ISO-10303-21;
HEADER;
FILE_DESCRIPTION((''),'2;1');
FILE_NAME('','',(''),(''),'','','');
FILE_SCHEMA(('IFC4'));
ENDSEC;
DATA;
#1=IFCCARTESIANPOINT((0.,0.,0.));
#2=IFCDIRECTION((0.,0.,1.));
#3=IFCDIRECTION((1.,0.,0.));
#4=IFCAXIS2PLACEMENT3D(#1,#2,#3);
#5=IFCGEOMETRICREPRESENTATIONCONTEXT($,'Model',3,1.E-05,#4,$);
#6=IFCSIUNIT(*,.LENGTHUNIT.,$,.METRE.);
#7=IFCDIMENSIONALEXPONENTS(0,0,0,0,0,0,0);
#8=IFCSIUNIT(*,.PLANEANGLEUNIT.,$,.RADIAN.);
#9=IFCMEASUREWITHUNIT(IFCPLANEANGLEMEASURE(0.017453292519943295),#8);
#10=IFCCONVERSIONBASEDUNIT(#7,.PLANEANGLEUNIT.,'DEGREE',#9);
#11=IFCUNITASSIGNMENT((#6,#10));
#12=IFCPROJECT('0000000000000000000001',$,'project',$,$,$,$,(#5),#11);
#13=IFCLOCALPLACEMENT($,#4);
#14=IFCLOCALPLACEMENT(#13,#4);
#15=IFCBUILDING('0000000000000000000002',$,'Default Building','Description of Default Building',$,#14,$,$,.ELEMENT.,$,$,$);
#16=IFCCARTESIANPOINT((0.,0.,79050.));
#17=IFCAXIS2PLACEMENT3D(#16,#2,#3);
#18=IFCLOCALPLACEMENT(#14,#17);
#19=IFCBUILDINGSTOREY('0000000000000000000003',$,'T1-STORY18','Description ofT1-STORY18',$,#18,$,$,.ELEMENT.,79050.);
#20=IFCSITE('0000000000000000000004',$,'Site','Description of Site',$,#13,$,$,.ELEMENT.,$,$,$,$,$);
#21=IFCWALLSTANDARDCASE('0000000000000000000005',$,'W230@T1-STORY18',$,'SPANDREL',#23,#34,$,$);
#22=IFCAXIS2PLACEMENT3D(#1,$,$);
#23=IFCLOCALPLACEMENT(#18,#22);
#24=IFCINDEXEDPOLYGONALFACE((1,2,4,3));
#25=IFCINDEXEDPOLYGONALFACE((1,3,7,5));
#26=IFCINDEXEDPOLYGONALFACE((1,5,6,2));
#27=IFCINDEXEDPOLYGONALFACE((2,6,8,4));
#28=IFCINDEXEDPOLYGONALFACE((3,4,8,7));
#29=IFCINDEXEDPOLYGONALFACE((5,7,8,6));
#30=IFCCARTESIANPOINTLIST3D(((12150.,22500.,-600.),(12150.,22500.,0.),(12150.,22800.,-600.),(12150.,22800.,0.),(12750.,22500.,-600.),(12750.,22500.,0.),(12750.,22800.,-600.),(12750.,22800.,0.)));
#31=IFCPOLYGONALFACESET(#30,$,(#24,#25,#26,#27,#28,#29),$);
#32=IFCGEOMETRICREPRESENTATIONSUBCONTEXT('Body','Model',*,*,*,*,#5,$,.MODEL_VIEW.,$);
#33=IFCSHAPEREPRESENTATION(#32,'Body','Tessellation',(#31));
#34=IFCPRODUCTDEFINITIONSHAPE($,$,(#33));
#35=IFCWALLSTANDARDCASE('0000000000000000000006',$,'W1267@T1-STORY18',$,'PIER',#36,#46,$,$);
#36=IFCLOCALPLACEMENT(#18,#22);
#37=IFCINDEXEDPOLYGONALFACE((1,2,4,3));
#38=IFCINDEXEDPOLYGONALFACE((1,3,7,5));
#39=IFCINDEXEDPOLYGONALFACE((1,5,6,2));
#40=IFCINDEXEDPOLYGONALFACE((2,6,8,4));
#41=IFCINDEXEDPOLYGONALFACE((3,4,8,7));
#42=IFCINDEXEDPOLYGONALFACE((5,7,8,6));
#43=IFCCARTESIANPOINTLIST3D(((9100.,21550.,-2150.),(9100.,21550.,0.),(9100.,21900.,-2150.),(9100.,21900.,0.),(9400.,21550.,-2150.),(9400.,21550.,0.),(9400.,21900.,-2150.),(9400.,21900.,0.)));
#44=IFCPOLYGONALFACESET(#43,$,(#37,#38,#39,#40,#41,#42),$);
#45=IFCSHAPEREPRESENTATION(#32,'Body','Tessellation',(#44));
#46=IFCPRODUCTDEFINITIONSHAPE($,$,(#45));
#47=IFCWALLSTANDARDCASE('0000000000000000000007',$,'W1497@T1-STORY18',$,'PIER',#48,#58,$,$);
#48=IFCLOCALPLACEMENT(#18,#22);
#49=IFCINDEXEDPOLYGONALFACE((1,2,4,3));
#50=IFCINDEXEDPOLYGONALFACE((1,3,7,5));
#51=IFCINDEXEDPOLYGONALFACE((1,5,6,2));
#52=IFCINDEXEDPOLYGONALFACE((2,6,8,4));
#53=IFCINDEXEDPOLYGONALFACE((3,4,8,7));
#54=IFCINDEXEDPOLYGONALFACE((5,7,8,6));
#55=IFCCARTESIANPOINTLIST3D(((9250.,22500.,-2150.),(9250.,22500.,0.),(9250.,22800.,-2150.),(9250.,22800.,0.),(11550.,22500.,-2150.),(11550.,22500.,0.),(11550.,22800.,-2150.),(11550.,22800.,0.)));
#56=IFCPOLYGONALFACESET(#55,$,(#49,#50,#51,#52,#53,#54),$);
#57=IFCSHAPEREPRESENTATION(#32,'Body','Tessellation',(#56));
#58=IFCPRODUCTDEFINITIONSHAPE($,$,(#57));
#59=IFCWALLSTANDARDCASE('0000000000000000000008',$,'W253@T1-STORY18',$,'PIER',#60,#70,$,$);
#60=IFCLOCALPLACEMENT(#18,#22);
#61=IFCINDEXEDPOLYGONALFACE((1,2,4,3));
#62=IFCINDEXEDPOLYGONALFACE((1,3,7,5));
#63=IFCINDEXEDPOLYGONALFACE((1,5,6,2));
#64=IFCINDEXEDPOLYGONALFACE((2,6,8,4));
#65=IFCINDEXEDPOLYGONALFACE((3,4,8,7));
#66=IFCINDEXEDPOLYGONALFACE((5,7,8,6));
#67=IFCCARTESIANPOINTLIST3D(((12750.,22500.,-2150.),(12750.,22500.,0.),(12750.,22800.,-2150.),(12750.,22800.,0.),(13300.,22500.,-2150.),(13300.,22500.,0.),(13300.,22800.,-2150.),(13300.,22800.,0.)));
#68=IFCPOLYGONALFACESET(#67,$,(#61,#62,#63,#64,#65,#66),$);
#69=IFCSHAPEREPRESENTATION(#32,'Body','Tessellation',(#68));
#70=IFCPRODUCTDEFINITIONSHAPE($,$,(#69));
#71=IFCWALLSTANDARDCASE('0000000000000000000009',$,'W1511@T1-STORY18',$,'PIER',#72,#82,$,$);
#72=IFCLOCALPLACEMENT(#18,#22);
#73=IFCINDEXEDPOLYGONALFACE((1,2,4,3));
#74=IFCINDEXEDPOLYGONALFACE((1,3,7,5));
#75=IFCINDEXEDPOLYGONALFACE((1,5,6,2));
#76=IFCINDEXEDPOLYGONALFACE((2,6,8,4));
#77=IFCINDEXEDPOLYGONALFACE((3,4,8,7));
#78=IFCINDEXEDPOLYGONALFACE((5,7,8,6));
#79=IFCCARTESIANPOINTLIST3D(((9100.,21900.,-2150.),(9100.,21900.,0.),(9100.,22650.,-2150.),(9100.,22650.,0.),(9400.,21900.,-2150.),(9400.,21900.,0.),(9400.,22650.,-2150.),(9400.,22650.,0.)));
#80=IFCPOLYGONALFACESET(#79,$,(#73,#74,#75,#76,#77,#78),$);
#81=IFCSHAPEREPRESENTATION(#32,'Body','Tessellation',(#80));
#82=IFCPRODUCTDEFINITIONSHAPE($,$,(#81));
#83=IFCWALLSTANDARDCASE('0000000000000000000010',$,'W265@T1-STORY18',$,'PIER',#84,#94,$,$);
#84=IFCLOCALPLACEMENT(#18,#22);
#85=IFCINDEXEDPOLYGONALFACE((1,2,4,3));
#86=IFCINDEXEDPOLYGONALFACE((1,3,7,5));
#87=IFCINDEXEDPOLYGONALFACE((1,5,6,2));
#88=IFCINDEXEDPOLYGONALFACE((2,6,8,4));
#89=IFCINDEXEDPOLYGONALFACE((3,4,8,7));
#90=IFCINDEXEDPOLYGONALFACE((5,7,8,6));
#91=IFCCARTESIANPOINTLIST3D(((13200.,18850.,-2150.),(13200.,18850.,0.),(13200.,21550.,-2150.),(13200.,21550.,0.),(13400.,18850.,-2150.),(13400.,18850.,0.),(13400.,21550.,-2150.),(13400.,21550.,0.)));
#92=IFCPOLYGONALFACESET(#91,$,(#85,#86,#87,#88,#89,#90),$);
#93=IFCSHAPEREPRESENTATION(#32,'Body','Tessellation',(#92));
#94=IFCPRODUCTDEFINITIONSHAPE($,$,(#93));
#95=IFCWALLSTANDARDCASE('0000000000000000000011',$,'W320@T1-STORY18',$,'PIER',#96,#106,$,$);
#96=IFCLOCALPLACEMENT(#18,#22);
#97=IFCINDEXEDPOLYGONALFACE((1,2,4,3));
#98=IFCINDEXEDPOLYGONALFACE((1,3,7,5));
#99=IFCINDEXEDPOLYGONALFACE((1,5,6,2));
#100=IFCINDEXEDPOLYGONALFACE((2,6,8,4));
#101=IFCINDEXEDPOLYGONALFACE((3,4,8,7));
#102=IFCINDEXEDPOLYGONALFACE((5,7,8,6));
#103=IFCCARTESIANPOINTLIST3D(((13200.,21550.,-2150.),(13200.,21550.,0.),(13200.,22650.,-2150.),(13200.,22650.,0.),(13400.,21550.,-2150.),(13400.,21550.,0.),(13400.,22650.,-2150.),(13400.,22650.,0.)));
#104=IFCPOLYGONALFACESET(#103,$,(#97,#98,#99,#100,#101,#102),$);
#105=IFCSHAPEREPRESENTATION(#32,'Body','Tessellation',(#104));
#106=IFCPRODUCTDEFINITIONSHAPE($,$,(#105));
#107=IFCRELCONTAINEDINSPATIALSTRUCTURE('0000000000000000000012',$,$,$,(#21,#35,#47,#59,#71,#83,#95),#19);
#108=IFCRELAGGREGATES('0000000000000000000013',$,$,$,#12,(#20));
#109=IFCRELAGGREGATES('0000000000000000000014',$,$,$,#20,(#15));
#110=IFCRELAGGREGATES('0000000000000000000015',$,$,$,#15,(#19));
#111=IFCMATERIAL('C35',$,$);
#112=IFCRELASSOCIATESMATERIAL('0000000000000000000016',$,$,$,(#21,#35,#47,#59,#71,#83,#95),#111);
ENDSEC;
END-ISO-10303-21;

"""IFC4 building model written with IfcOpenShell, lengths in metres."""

from ifc_helpers import new_model, entity, si_unit, converted_unit, frame, origin_with_axes, place, context, subcontext, project, spatial, indexed_curve, outline, extrude, material, element, save


model = new_model("IFC4")

# Units and contexts
model_context = context("Model", 3, precision=1e-05, world=origin_with_axes())
body_context = subcontext(model_context, "Body", "Model", "MODEL_VIEW")
ifc_project = project(units=[si_unit("LENGTHUNIT", "METRE"), converted_unit("PLANEANGLEUNIT", "DEGREE", entity("IfcPlaneAngleMeasure", 0.017453292519943295), si_unit("PLANEANGLEUNIT", "RADIAN"), dimensions=[0, 0, 0, 0, 0, 0, 0])], contexts=[model_context])

# Site, building, storey
site_placement = place(None, origin_with_axes())
site = spatial("IfcSite", under=ifc_project, at=site_placement, Name="Site", Description="Description of Site", CompositionType="ELEMENT")
building_placement = place(site_placement, origin_with_axes())
building = spatial("IfcBuilding", under=site, at=building_placement, Name="Default Building", Description="Description of Default Building", CompositionType="ELEMENT")
storey_placement = place(building_placement, frame((0.0, 0.0, 79050.0), z_axis=(0.0, 0.0, 1.0), x_axis=(1.0, 0.0, 0.0)))
storey = spatial("IfcBuildingStorey", under=building, at=storey_placement, Name="T1-STORY18", Description="Description ofT1-STORY18", CompositionType="ELEMENT", Elevation=79050.0)

# Shared definitions
ifc_material_1 = material(Name="C35")

# Walls
for number, where, z_axis, x_axis, name in (
    (1, (12150.0, 22650.0, -600.0), (0.0, 0.0, 1.0), (1.0, 0.0, 0.0), "W230@T1-STORY18"),
):
    element("IfcWallStandardCase", number, at=place(storey_placement, frame(where, z_axis=z_axis, x_axis=x_axis)), inside=storey, material=ifc_material_1, Name=name, ObjectType="SPANDREL", context=body_context, shape_type="SweptSolid", body=[
        extrude(outline(indexed_curve([(0.0, -150.0), (0.0, 150.0), (600.0, 150.0), (600.0, -150.0), (0.0, -150.0)], self_intersect=False)), origin_with_axes(), (0.0, 0.0, 1.0), 600.0),
    ])
wall_1_placement = place(storey_placement, frame((9250.0, 21550.0, -2150.0), z_axis=(0.0, 0.0, 1.0), x_axis=(0.0, 1.0, 0.0)))
element("IfcWallStandardCase", 2, at=wall_1_placement, inside=storey, material=ifc_material_1, Name="W1267@T1-STORY18", ObjectType="PIER", context=body_context, shape_type="SweptSolid", body=[
    extrude(outline(indexed_curve([(0.0, -150.0), (0.0, 150.0), (350.0, 150.0), (350.0, -150.0), (0.0, -150.0)], self_intersect=False)), origin_with_axes(), (0.0, 0.0, 1.0), 2150.0),
])
wall_2_placement = place(storey_placement, frame((9250.0, 22650.0, -2150.0), z_axis=(0.0, 0.0, 1.0), x_axis=(1.0, 0.0, 0.0)))
element("IfcWallStandardCase", 3, at=wall_2_placement, inside=storey, material=ifc_material_1, Name="W1497@T1-STORY18", ObjectType="PIER", context=body_context, shape_type="SweptSolid", body=[
    extrude(outline(indexed_curve([(0.0, -150.0), (0.0, 150.0), (2300.0, 150.0), (2300.0, -150.0), (0.0, -150.0)], self_intersect=False)), origin_with_axes(), (0.0, 0.0, 1.0), 2150.0),
])
wall_3_placement = place(storey_placement, frame((12750.0, 22650.0, -2150.0), z_axis=(0.0, 0.0, 1.0), x_axis=(1.0, 0.0, 0.0)))
element("IfcWallStandardCase", 4, at=wall_3_placement, inside=storey, material=ifc_material_1, Name="W253@T1-STORY18", ObjectType="PIER", context=body_context, shape_type="SweptSolid", body=[
    extrude(outline(indexed_curve([(0.0, -150.0), (0.0, 150.0), (550.0, 150.0), (550.0, -150.0), (0.0, -150.0)], self_intersect=False)), origin_with_axes(), (0.0, 0.0, 1.0), 2150.0),
])
wall_4_placement = place(storey_placement, frame((9250.0, 21900.0, -2150.0), z_axis=(0.0, 0.0, 1.0), x_axis=(0.0, 1.0, 0.0)))
element("IfcWallStandardCase", 5, at=wall_4_placement, inside=storey, material=ifc_material_1, Name="W1511@T1-STORY18", ObjectType="PIER", context=body_context, shape_type="SweptSolid", body=[
    extrude(outline(indexed_curve([(0.0, -150.0), (0.0, 150.0), (750.0, 150.0), (750.0, -150.0), (0.0, -150.0)], self_intersect=False)), origin_with_axes(), (0.0, 0.0, 1.0), 2150.0),
])
wall_5_placement = place(storey_placement, frame((13300.0, 18850.0, -2150.0), z_axis=(0.0, 0.0, 1.0), x_axis=(0.0, 1.0, 0.0)))
element("IfcWallStandardCase", 6, at=wall_5_placement, inside=storey, material=ifc_material_1, Name="W265@T1-STORY18", ObjectType="PIER", context=body_context, shape_type="SweptSolid", body=[
    extrude(outline(indexed_curve([(0.0, -100.0), (0.0, 100.0), (2700.0, 100.0), (2700.0, -100.0), (0.0, -100.0)], self_intersect=False)), origin_with_axes(), (0.0, 0.0, 1.0), 2150.0),
])
wall_6_placement = place(storey_placement, frame((13300.0, 21550.0, -2150.0), z_axis=(0.0, 0.0, 1.0), x_axis=(0.0, 1.0, 0.0)))
element("IfcWallStandardCase", 7, at=wall_6_placement, inside=storey, material=ifc_material_1, Name="W320@T1-STORY18", ObjectType="PIER", context=body_context, shape_type="SweptSolid", body=[
    extrude(outline(indexed_curve([(0.0, -100.0), (0.0, 100.0), (1100.0, 100.0), (1100.0, -100.0), (0.0, -100.0)], self_intersect=False)), origin_with_axes(), (0.0, 0.0, 1.0), 2150.0),
])

save(model, "model.ifc")
